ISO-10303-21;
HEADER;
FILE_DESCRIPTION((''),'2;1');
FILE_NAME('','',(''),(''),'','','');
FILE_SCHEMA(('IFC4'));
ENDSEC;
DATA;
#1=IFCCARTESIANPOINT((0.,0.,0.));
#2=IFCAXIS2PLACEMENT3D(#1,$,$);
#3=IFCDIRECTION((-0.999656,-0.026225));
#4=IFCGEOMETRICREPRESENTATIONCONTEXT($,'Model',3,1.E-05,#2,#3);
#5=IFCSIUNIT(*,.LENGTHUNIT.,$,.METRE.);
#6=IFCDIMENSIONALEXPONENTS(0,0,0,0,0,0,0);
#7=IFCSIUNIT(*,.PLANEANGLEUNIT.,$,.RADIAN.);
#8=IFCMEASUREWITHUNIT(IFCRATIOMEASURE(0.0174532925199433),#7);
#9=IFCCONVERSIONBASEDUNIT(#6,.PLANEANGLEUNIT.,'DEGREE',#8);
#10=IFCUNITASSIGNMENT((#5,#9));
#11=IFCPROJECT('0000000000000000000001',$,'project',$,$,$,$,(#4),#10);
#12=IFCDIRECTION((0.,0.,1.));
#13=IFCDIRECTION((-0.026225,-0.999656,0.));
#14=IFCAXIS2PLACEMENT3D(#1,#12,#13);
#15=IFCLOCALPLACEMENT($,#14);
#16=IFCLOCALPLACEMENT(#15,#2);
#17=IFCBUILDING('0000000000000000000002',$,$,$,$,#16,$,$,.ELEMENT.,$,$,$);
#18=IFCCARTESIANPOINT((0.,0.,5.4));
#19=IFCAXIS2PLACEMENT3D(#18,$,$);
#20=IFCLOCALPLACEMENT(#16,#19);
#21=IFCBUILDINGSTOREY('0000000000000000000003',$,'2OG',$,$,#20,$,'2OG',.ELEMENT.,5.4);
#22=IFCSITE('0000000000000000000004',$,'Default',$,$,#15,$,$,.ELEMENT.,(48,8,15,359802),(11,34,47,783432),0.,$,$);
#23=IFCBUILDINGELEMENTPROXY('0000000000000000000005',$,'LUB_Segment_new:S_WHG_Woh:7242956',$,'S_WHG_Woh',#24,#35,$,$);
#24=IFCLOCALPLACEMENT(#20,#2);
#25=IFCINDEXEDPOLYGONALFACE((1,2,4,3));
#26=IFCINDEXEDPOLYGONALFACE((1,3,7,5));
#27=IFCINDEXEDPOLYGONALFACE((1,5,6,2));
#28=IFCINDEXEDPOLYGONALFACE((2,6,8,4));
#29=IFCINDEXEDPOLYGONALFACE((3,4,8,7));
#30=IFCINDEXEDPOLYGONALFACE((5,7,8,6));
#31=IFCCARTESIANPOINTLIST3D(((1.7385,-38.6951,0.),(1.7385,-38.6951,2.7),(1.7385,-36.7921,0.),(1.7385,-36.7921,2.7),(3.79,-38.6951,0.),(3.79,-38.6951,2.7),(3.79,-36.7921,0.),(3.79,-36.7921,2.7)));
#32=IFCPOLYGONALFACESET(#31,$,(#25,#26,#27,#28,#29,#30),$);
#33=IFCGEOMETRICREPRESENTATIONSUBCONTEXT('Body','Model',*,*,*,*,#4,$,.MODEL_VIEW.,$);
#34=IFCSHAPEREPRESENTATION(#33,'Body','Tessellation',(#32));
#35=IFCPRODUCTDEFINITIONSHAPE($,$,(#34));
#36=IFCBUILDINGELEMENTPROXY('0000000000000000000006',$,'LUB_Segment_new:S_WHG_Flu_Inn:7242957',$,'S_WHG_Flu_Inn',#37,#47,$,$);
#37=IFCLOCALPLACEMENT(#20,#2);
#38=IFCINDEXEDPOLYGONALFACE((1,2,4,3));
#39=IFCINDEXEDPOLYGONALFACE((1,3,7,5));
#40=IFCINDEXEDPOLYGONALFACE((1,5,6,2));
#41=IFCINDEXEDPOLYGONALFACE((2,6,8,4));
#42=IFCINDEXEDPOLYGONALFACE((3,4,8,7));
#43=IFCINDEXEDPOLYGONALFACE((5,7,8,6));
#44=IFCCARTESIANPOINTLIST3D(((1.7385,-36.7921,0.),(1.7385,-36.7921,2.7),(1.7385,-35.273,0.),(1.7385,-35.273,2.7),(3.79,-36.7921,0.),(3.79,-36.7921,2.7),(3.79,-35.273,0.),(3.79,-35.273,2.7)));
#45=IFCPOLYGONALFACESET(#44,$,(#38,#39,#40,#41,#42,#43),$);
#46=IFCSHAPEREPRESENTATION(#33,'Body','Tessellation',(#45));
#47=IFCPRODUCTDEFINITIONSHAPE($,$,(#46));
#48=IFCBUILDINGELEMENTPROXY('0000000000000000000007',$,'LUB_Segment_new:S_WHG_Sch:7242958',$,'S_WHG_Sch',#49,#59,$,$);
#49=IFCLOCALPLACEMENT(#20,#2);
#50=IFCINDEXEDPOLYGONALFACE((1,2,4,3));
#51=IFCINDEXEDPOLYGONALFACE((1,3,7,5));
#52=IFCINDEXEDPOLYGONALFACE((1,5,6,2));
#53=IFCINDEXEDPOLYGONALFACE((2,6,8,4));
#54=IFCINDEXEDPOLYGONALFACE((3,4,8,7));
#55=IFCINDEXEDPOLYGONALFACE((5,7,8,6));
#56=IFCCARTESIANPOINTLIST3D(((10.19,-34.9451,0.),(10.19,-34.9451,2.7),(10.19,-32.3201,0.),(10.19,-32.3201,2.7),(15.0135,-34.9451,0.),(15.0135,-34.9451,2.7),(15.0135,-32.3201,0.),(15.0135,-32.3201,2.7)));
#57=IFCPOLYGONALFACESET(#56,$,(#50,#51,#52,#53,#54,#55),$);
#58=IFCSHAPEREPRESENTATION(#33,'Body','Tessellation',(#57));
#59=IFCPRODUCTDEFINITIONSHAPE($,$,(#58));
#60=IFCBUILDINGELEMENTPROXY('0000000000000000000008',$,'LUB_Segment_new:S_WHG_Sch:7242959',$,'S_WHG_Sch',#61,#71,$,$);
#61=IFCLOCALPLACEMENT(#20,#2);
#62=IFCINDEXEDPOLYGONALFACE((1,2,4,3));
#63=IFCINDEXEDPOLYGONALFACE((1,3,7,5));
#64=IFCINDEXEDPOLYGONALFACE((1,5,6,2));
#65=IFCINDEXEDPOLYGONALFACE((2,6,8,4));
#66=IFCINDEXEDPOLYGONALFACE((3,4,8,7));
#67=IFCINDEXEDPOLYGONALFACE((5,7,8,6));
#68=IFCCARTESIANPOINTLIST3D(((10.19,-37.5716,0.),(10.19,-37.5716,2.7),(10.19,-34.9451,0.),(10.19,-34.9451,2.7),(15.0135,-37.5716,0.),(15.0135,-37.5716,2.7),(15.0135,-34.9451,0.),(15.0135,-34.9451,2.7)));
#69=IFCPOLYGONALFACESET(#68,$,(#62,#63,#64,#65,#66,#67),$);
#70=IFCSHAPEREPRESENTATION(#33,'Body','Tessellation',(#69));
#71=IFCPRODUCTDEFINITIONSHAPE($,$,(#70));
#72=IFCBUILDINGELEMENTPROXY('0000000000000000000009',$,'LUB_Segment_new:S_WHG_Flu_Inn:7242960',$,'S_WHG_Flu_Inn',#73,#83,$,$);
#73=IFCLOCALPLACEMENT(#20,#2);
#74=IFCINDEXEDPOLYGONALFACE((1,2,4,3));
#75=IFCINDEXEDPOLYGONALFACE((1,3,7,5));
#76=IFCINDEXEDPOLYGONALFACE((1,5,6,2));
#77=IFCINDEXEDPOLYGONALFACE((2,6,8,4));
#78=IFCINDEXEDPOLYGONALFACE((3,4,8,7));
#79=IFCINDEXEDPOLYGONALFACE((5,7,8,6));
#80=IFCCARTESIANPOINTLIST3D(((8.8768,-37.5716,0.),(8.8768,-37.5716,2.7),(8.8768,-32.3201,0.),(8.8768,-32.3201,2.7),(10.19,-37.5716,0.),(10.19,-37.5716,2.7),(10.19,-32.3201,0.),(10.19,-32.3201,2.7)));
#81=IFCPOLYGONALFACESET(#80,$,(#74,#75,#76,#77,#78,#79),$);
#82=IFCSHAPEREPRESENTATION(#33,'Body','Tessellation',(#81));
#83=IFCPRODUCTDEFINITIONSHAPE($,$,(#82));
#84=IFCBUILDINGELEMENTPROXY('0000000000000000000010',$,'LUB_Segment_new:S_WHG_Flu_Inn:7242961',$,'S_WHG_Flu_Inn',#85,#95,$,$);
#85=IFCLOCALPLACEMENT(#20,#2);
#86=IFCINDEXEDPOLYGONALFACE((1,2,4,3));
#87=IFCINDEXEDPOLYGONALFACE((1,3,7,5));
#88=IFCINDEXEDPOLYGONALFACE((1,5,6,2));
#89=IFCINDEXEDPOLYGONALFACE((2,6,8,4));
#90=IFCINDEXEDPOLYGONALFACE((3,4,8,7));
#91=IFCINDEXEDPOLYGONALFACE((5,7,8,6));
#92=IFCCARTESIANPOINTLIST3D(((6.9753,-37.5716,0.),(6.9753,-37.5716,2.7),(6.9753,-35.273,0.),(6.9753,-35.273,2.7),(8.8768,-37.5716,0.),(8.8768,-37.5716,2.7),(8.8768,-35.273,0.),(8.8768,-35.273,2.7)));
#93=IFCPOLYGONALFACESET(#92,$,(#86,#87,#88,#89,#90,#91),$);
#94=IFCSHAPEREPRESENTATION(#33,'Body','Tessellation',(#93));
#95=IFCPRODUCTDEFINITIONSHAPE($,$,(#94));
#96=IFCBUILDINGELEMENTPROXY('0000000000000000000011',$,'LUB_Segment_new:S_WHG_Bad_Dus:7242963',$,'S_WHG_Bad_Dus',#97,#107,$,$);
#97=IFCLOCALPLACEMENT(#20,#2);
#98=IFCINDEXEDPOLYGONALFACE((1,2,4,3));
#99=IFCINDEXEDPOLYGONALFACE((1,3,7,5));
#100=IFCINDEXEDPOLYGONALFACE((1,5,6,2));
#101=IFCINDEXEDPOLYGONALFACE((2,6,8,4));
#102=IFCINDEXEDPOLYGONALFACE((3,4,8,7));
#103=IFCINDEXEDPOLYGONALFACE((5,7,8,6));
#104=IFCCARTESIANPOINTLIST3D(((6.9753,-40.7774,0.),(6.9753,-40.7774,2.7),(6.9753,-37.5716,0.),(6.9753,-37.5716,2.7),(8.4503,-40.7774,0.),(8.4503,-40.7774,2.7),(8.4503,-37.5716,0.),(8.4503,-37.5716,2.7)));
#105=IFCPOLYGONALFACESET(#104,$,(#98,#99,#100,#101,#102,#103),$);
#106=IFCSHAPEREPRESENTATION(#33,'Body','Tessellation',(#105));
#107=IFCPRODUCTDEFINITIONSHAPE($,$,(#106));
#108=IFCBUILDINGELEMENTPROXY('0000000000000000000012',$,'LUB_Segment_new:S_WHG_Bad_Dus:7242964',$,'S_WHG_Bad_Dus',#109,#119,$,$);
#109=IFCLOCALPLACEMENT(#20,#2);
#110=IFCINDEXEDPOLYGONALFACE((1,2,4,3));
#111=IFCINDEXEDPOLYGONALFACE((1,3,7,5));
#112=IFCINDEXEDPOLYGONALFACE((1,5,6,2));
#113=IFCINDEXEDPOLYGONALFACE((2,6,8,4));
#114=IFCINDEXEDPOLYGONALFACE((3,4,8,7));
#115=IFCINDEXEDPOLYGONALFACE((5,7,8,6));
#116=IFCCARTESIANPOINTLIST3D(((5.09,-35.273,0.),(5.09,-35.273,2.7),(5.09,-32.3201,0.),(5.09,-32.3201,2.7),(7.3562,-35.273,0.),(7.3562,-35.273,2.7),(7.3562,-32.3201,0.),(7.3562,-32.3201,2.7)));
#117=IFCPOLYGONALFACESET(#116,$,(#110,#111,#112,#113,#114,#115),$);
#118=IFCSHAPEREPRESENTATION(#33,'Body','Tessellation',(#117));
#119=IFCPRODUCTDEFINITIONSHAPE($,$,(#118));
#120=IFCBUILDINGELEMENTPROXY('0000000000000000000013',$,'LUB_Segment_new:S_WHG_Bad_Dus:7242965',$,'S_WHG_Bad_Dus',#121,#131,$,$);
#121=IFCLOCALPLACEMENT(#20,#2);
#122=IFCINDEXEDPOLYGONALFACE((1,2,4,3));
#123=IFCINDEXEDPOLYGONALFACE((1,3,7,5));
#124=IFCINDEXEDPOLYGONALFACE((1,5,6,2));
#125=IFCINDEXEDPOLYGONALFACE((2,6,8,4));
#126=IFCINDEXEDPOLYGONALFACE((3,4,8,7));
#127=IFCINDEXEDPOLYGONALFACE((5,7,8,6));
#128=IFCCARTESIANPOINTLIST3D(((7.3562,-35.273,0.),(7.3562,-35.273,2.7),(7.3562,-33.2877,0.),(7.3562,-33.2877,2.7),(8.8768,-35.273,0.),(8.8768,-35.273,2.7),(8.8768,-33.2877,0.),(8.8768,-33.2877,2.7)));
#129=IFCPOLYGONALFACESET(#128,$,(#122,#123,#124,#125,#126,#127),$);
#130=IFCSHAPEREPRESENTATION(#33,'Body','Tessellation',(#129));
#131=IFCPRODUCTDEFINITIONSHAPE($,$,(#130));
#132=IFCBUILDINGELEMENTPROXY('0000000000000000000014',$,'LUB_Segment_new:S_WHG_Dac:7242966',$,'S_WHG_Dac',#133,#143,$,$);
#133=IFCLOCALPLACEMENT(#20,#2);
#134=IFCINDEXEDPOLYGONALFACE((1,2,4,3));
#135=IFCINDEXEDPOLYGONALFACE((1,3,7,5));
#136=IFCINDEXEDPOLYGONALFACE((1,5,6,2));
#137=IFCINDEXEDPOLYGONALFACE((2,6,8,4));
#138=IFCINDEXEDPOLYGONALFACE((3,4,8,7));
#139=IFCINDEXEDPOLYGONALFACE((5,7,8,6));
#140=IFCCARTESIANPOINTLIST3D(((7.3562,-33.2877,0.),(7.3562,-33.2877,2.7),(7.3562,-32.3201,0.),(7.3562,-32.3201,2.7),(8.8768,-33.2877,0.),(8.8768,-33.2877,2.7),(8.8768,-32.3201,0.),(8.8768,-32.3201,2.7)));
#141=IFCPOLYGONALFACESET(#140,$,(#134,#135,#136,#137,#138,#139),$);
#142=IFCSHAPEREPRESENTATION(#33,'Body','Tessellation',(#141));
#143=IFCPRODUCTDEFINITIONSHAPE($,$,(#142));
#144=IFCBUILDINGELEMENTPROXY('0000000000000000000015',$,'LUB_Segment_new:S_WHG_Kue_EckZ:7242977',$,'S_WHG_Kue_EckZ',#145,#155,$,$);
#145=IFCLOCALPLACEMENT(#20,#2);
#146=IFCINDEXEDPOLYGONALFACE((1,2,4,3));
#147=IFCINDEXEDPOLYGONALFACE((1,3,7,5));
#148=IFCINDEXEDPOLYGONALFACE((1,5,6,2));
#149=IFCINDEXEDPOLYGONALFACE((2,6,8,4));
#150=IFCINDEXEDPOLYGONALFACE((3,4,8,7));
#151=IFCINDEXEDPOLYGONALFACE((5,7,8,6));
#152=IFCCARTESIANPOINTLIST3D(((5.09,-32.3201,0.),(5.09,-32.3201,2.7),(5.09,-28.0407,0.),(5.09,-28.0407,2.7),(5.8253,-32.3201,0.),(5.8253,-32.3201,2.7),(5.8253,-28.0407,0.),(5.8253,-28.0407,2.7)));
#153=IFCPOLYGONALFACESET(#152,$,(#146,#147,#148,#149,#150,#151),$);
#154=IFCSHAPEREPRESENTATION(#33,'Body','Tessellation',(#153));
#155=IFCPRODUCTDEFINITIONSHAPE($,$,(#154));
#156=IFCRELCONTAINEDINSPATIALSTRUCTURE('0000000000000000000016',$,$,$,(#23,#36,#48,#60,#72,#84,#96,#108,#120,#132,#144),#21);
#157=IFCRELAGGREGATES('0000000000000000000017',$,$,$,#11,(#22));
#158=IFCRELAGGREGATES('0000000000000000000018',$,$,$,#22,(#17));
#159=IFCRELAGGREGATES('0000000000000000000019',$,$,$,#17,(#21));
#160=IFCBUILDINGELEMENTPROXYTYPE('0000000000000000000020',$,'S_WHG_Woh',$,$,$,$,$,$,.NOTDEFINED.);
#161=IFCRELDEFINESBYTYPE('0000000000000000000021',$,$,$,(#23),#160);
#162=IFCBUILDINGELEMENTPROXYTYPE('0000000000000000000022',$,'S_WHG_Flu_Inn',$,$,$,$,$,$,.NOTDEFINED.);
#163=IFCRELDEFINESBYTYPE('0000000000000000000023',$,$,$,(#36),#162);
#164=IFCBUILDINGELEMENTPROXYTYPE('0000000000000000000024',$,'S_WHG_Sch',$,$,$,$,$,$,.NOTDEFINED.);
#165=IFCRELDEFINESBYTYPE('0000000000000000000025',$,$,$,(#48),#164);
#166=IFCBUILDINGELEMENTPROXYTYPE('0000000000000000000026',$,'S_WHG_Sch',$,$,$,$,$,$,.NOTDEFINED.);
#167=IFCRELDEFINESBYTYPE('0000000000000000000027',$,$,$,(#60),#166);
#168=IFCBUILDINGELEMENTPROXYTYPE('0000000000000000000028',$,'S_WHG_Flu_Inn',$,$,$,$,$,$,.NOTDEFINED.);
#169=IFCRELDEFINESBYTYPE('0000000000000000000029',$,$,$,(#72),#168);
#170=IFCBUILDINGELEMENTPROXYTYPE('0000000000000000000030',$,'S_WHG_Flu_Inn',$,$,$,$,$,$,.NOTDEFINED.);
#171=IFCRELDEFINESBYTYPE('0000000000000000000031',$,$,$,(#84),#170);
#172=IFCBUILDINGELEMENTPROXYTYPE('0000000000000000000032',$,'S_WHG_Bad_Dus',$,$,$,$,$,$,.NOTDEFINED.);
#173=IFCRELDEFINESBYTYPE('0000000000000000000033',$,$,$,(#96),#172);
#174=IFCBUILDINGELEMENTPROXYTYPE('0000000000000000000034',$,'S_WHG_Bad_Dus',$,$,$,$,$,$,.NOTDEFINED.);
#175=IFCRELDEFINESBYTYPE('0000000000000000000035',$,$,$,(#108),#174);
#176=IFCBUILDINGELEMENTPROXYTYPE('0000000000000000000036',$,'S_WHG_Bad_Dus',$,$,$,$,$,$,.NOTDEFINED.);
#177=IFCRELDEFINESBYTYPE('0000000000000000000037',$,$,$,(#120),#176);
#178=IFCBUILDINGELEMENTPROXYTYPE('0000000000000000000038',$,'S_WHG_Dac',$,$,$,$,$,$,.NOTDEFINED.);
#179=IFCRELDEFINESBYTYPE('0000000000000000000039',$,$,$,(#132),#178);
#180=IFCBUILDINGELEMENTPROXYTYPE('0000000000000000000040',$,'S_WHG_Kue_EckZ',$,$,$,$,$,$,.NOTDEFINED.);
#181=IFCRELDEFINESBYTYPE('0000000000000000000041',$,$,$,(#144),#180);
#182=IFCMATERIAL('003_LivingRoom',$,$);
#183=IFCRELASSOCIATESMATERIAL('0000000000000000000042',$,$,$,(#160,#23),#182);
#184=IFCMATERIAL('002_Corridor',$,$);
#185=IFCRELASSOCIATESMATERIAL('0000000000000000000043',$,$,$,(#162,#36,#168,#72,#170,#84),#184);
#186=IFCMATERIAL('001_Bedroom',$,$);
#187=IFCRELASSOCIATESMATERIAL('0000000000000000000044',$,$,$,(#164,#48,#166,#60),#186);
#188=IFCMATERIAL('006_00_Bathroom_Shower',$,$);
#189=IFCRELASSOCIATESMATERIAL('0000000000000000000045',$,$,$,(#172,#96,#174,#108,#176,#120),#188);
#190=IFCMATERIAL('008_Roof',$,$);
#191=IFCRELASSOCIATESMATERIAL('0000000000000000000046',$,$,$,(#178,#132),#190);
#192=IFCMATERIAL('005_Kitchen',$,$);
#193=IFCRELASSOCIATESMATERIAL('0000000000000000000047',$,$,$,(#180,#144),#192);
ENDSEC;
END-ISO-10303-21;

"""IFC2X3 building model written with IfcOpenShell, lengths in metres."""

from ifc_helpers import new_model, entity, si_unit, converted_unit, direction, frame, frame_2d, origin, origin_2d_with_axis, place, context, subcontext, project, spatial, rectangle, extrude, source, transform, mapped, material, type_object, type_shapes, element, save


model = new_model("IFC2X3")

# Units and contexts
model_context = context("Model", 3, precision=1e-05, world=origin(), true_north=direction((-0.999656, -0.026225)))
body_context = subcontext(model_context, "Body", "Model", "MODEL_VIEW")
ifc_project = project(units=[si_unit("LENGTHUNIT", "METRE"), converted_unit("PLANEANGLEUNIT", "DEGREE", entity("IfcRatioMeasure", 0.0174532925199433), si_unit("PLANEANGLEUNIT", "RADIAN"), dimensions=[0, 0, 0, 0, 0, 0, 0])], contexts=[model_context])

# Site, building, storey
site_placement = place(None, frame((0.0, 0.0, 0.0), z_axis=(0.0, 0.0, 1.0), x_axis=(-0.026225, -0.999656, 0.0)))
site = spatial("IfcSite", under=ifc_project, at=site_placement, Name="Default", CompositionType="ELEMENT", RefLatitude=(48, 8, 15, 359802), RefLongitude=(11, 34, 47, 783432), RefElevation=0.0)
building_placement = place(site_placement, origin())
building = spatial("IfcBuilding", under=site, at=building_placement, CompositionType="ELEMENT")
storey_placement = place(building_placement, frame((0.0, 0.0, 5.4)))
storey = spatial("IfcBuildingStorey", under=building, at=storey_placement, Name="2OG", LongName="2OG", CompositionType="ELEMENT", Elevation=5.4)

# Building element proxies
ifc_material_1 = material(Name="001_Bedroom")
ifc_material_2 = material(Name="002_Corridor")
ifc_material_3 = material(Name="006_00_Bathroom_Shower")
ifc_material_4 = material(Name="005_Kitchen")
ifc_material_5 = material(Name="003_LivingRoom")
building_element_proxy_type_1 = type_object("IfcBuildingElementProxyType", Name="S_WHG_Woh", PredefinedType="NOTDEFINED", material=ifc_material_5)
shared_shape_1 = source(origin(), body_context, "Body", "SweptSolid", [
    extrude(rectangle(XDim=2.0515, YDim=1.9029, at=origin_2d_with_axis()), frame((0.0, 0.0, 0.0), z_axis=(0.0, 0.0, 1.0), x_axis=(-1.0, 0.0, 0.0)), (0.0, 0.0, 1.0), 2.7),
])
type_shapes(building_element_proxy_type_1, [shared_shape_1])
proxy_1_placement = place(storey_placement, frame((2.7643, -37.7436, 0.0)))
element("IfcBuildingElementProxy", 1, at=proxy_1_placement, inside=storey, type_object=building_element_proxy_type_1, material=ifc_material_5, Name="LUB_Segment_new:S_WHG_Woh:7242956", ObjectType="S_WHG_Woh", context=body_context, shape_type="MappedRepresentation", body=[
    mapped(shared_shape_1, transform((0.0, 0.0, 0.0), scale=1.0)),
])
building_element_proxy_type_2 = type_object("IfcBuildingElementProxyType", Name="S_WHG_Flu_Inn", PredefinedType="NOTDEFINED", material=ifc_material_2)
shared_shape_2 = source(origin(), body_context, "Body", "SweptSolid", [
    extrude(rectangle(XDim=2.0515, YDim=1.5191, at=origin_2d_with_axis()), frame((0.0, 0.0, 0.0), z_axis=(0.0, 0.0, 1.0), x_axis=(-1.0, 0.0, 0.0)), (0.0, 0.0, 1.0), 2.7),
])
type_shapes(building_element_proxy_type_2, [shared_shape_2])
proxy_2_placement = place(storey_placement, frame((2.7643, -36.0326, 0.0)))
element("IfcBuildingElementProxy", 2, at=proxy_2_placement, inside=storey, type_object=building_element_proxy_type_2, material=ifc_material_2, Name="LUB_Segment_new:S_WHG_Flu_Inn:7242957", ObjectType="S_WHG_Flu_Inn", context=body_context, shape_type="MappedRepresentation", body=[
    mapped(shared_shape_2, transform((0.0, 0.0, 0.0), scale=1.0)),
])
building_element_proxy_type_3 = type_object("IfcBuildingElementProxyType", Name="S_WHG_Sch", PredefinedType="NOTDEFINED", material=ifc_material_1)
shared_shape_3 = source(origin(), body_context, "Body", "SweptSolid", [
    extrude(rectangle(XDim=4.8235, YDim=2.625, at=origin_2d_with_axis()), frame((0.0, 0.0, 0.0), z_axis=(0.0, 0.0, 1.0), x_axis=(-1.0, 0.0, 0.0)), (0.0, 0.0, 1.0), 2.7),
])
type_shapes(building_element_proxy_type_3, [shared_shape_3])
proxy_3_placement = place(storey_placement, frame((12.6018, -33.6326, 0.0)))
element("IfcBuildingElementProxy", 3, at=proxy_3_placement, inside=storey, type_object=building_element_proxy_type_3, material=ifc_material_1, Name="LUB_Segment_new:S_WHG_Sch:7242958", ObjectType="S_WHG_Sch", context=body_context, shape_type="MappedRepresentation", body=[
    mapped(shared_shape_3, transform((0.0, 0.0, 0.0), scale=1.0)),
])
building_element_proxy_type_4 = type_object("IfcBuildingElementProxyType", Name="S_WHG_Sch", PredefinedType="NOTDEFINED", material=ifc_material_1)
shared_shape_4 = source(origin(), body_context, "Body", "SweptSolid", [
    extrude(rectangle(XDim=4.8235, YDim=2.6265, at=origin_2d_with_axis()), frame((0.0, 0.0, 0.0), z_axis=(0.0, 0.0, 1.0), x_axis=(-1.0, 0.0, 0.0)), (0.0, 0.0, 1.0), 2.7),
])
type_shapes(building_element_proxy_type_4, [shared_shape_4])
proxy_4_placement = place(storey_placement, frame((12.6018, -36.2583, 0.0)))
element("IfcBuildingElementProxy", 4, at=proxy_4_placement, inside=storey, type_object=building_element_proxy_type_4, material=ifc_material_1, Name="LUB_Segment_new:S_WHG_Sch:7242959", ObjectType="S_WHG_Sch", context=body_context, shape_type="MappedRepresentation", body=[
    mapped(shared_shape_4, transform((0.0, 0.0, 0.0), scale=1.0)),
])
building_element_proxy_type_5 = type_object("IfcBuildingElementProxyType", Name="S_WHG_Flu_Inn", PredefinedType="NOTDEFINED", material=ifc_material_2)
shared_shape_5 = source(origin(), body_context, "Body", "SweptSolid", [
    extrude(rectangle(XDim=1.3132, YDim=5.2515, at=origin_2d_with_axis()), frame((0.0, 0.0, 0.0), z_axis=(0.0, 0.0, 1.0), x_axis=(-1.0, 0.0, 0.0)), (0.0, 0.0, 1.0), 2.7),
])
type_shapes(building_element_proxy_type_5, [shared_shape_5])
proxy_5_placement = place(storey_placement, frame((9.5334, -34.9458, 0.0)))
element("IfcBuildingElementProxy", 5, at=proxy_5_placement, inside=storey, type_object=building_element_proxy_type_5, material=ifc_material_2, Name="LUB_Segment_new:S_WHG_Flu_Inn:7242960", ObjectType="S_WHG_Flu_Inn", context=body_context, shape_type="MappedRepresentation", body=[
    mapped(shared_shape_5, transform((0.0, 0.0, 0.0), scale=1.0)),
])
building_element_proxy_type_6 = type_object("IfcBuildingElementProxyType", Name="S_WHG_Flu_Inn", PredefinedType="NOTDEFINED", material=ifc_material_2)
shared_shape_6 = source(origin(), body_context, "Body", "SweptSolid", [
    extrude(rectangle(XDim=1.9015, YDim=2.2985, at=origin_2d_with_axis()), frame((0.0, 0.0, 0.0), z_axis=(0.0, 0.0, 1.0), x_axis=(-1.0, 0.0, 0.0)), (0.0, 0.0, 1.0), 2.7),
])
type_shapes(building_element_proxy_type_6, [shared_shape_6])
proxy_6_placement = place(storey_placement, frame((7.926, -36.4223, 0.0)))
element("IfcBuildingElementProxy", 6, at=proxy_6_placement, inside=storey, type_object=building_element_proxy_type_6, material=ifc_material_2, Name="LUB_Segment_new:S_WHG_Flu_Inn:7242961", ObjectType="S_WHG_Flu_Inn", context=body_context, shape_type="MappedRepresentation", body=[
    mapped(shared_shape_6, transform((0.0, 0.0, 0.0), scale=1.0)),
])
building_element_proxy_type_7 = type_object("IfcBuildingElementProxyType", Name="S_WHG_Bad_Dus", PredefinedType="NOTDEFINED", material=ifc_material_3)
shared_shape_7 = source(origin(), body_context, "Body", "SweptSolid", [
    extrude(rectangle(XDim=3.2059, YDim=1.475, at=origin_2d_with_axis()), frame((0.0, 0.0, 0.0), z_axis=(0.0, 0.0, 1.0), x_axis=(0.0, 1.0, 0.0)), (0.0, 0.0, 1.0), 2.7),
])
type_shapes(building_element_proxy_type_7, [shared_shape_7])
proxy_7_placement = place(storey_placement, frame((7.7128, -39.1745, 0.0)))
element("IfcBuildingElementProxy", 7, at=proxy_7_placement, inside=storey, type_object=building_element_proxy_type_7, material=ifc_material_3, Name="LUB_Segment_new:S_WHG_Bad_Dus:7242963", ObjectType="S_WHG_Bad_Dus", context=body_context, shape_type="MappedRepresentation", body=[
    mapped(shared_shape_7, transform((0.0, 0.0, 0.0), scale=1.0)),
])
building_element_proxy_type_8 = type_object("IfcBuildingElementProxyType", Name="S_WHG_Bad_Dus", PredefinedType="NOTDEFINED", material=ifc_material_3)
shared_shape_8 = source(origin(), body_context, "Body", "SweptSolid", [
    extrude(rectangle(XDim=2.9529, YDim=2.2662, at=origin_2d_with_axis()), frame((0.0, 0.0, 0.0), z_axis=(0.0, 0.0, 1.0), x_axis=(0.0, 1.0, 0.0)), (0.0, 0.0, 1.0), 2.7),
])
type_shapes(building_element_proxy_type_8, [shared_shape_8])
proxy_8_placement = place(storey_placement, frame((6.2231, -33.7966, 0.0)))
element("IfcBuildingElementProxy", 8, at=proxy_8_placement, inside=storey, type_object=building_element_proxy_type_8, material=ifc_material_3, Name="LUB_Segment_new:S_WHG_Bad_Dus:7242964", ObjectType="S_WHG_Bad_Dus", context=body_context, shape_type="MappedRepresentation", body=[
    mapped(shared_shape_8, transform((0.0, 0.0, 0.0), scale=1.0)),
])
building_element_proxy_type_9 = type_object("IfcBuildingElementProxyType", Name="S_WHG_Bad_Dus", PredefinedType="NOTDEFINED", material=ifc_material_3)
shared_shape_9 = source(origin(), body_context, "Body", "SweptSolid", [
    extrude(rectangle(XDim=1.9853, YDim=1.5206, at=origin_2d_with_axis()), frame((0.0, 0.0, 0.0), z_axis=(0.0, 0.0, 1.0), x_axis=(0.0, 1.0, 0.0)), (0.0, 0.0, 1.0), 2.7),
])
type_shapes(building_element_proxy_type_9, [shared_shape_9])
proxy_9_placement = place(storey_placement, frame((8.1165, -34.2804, 0.0)))
element("IfcBuildingElementProxy", 9, at=proxy_9_placement, inside=storey, type_object=building_element_proxy_type_9, material=ifc_material_3, Name="LUB_Segment_new:S_WHG_Bad_Dus:7242965", ObjectType="S_WHG_Bad_Dus", context=body_context, shape_type="MappedRepresentation", body=[
    mapped(shared_shape_9, transform((0.0, 0.0, 0.0), scale=1.0)),
])
ifc_material_6 = material(Name="008_Roof")
building_element_proxy_type_10 = type_object("IfcBuildingElementProxyType", Name="S_WHG_Dac", PredefinedType="NOTDEFINED", material=ifc_material_6)
shared_shape_10 = source(origin(), body_context, "Body", "SweptSolid", [
    extrude(rectangle(XDim=0.9676, YDim=1.5206, at=frame_2d((0.0, 0.0), x_axis=(1.0, 0.0))), frame((0.0, 0.0, 0.0), z_axis=(0.0, 0.0, 1.0), x_axis=(0.0, 1.0, 0.0)), (0.0, 0.0, 1.0), 2.7),
])
type_shapes(building_element_proxy_type_10, [shared_shape_10])
proxy_10_placement = place(storey_placement, frame((8.1165, -32.8039, 0.0)))
element("IfcBuildingElementProxy", 10, at=proxy_10_placement, inside=storey, type_object=building_element_proxy_type_10, material=ifc_material_6, Name="LUB_Segment_new:S_WHG_Dac:7242966", ObjectType="S_WHG_Dac", context=body_context, shape_type="MappedRepresentation", body=[
    mapped(shared_shape_10, transform((0.0, 0.0, 0.0), scale=1.0)),
])
building_element_proxy_type_11 = type_object("IfcBuildingElementProxyType", Name="S_WHG_Kue_EckZ", PredefinedType="NOTDEFINED", material=ifc_material_4)
shared_shape_11 = source(origin(), body_context, "Body", "SweptSolid", [
    extrude(rectangle(XDim=4.2794, YDim=0.7353, at=origin_2d_with_axis()), frame((0.0, 0.0, 0.0), z_axis=(0.0, 0.0, 1.0), x_axis=(0.0, 1.0, 0.0)), (0.0, 0.0, 1.0), 2.7),
])
type_shapes(building_element_proxy_type_11, [shared_shape_11])
proxy_11_placement = place(storey_placement, frame((5.4577, -30.1804, 0.0)))
element("IfcBuildingElementProxy", 11, at=proxy_11_placement, inside=storey, type_object=building_element_proxy_type_11, material=ifc_material_4, Name="LUB_Segment_new:S_WHG_Kue_EckZ:7242977", ObjectType="S_WHG_Kue_EckZ", context=body_context, shape_type="MappedRepresentation", body=[
    mapped(shared_shape_11, transform((0.0, 0.0, 0.0), scale=1.0)),
])

save(model, "model.ifc")
